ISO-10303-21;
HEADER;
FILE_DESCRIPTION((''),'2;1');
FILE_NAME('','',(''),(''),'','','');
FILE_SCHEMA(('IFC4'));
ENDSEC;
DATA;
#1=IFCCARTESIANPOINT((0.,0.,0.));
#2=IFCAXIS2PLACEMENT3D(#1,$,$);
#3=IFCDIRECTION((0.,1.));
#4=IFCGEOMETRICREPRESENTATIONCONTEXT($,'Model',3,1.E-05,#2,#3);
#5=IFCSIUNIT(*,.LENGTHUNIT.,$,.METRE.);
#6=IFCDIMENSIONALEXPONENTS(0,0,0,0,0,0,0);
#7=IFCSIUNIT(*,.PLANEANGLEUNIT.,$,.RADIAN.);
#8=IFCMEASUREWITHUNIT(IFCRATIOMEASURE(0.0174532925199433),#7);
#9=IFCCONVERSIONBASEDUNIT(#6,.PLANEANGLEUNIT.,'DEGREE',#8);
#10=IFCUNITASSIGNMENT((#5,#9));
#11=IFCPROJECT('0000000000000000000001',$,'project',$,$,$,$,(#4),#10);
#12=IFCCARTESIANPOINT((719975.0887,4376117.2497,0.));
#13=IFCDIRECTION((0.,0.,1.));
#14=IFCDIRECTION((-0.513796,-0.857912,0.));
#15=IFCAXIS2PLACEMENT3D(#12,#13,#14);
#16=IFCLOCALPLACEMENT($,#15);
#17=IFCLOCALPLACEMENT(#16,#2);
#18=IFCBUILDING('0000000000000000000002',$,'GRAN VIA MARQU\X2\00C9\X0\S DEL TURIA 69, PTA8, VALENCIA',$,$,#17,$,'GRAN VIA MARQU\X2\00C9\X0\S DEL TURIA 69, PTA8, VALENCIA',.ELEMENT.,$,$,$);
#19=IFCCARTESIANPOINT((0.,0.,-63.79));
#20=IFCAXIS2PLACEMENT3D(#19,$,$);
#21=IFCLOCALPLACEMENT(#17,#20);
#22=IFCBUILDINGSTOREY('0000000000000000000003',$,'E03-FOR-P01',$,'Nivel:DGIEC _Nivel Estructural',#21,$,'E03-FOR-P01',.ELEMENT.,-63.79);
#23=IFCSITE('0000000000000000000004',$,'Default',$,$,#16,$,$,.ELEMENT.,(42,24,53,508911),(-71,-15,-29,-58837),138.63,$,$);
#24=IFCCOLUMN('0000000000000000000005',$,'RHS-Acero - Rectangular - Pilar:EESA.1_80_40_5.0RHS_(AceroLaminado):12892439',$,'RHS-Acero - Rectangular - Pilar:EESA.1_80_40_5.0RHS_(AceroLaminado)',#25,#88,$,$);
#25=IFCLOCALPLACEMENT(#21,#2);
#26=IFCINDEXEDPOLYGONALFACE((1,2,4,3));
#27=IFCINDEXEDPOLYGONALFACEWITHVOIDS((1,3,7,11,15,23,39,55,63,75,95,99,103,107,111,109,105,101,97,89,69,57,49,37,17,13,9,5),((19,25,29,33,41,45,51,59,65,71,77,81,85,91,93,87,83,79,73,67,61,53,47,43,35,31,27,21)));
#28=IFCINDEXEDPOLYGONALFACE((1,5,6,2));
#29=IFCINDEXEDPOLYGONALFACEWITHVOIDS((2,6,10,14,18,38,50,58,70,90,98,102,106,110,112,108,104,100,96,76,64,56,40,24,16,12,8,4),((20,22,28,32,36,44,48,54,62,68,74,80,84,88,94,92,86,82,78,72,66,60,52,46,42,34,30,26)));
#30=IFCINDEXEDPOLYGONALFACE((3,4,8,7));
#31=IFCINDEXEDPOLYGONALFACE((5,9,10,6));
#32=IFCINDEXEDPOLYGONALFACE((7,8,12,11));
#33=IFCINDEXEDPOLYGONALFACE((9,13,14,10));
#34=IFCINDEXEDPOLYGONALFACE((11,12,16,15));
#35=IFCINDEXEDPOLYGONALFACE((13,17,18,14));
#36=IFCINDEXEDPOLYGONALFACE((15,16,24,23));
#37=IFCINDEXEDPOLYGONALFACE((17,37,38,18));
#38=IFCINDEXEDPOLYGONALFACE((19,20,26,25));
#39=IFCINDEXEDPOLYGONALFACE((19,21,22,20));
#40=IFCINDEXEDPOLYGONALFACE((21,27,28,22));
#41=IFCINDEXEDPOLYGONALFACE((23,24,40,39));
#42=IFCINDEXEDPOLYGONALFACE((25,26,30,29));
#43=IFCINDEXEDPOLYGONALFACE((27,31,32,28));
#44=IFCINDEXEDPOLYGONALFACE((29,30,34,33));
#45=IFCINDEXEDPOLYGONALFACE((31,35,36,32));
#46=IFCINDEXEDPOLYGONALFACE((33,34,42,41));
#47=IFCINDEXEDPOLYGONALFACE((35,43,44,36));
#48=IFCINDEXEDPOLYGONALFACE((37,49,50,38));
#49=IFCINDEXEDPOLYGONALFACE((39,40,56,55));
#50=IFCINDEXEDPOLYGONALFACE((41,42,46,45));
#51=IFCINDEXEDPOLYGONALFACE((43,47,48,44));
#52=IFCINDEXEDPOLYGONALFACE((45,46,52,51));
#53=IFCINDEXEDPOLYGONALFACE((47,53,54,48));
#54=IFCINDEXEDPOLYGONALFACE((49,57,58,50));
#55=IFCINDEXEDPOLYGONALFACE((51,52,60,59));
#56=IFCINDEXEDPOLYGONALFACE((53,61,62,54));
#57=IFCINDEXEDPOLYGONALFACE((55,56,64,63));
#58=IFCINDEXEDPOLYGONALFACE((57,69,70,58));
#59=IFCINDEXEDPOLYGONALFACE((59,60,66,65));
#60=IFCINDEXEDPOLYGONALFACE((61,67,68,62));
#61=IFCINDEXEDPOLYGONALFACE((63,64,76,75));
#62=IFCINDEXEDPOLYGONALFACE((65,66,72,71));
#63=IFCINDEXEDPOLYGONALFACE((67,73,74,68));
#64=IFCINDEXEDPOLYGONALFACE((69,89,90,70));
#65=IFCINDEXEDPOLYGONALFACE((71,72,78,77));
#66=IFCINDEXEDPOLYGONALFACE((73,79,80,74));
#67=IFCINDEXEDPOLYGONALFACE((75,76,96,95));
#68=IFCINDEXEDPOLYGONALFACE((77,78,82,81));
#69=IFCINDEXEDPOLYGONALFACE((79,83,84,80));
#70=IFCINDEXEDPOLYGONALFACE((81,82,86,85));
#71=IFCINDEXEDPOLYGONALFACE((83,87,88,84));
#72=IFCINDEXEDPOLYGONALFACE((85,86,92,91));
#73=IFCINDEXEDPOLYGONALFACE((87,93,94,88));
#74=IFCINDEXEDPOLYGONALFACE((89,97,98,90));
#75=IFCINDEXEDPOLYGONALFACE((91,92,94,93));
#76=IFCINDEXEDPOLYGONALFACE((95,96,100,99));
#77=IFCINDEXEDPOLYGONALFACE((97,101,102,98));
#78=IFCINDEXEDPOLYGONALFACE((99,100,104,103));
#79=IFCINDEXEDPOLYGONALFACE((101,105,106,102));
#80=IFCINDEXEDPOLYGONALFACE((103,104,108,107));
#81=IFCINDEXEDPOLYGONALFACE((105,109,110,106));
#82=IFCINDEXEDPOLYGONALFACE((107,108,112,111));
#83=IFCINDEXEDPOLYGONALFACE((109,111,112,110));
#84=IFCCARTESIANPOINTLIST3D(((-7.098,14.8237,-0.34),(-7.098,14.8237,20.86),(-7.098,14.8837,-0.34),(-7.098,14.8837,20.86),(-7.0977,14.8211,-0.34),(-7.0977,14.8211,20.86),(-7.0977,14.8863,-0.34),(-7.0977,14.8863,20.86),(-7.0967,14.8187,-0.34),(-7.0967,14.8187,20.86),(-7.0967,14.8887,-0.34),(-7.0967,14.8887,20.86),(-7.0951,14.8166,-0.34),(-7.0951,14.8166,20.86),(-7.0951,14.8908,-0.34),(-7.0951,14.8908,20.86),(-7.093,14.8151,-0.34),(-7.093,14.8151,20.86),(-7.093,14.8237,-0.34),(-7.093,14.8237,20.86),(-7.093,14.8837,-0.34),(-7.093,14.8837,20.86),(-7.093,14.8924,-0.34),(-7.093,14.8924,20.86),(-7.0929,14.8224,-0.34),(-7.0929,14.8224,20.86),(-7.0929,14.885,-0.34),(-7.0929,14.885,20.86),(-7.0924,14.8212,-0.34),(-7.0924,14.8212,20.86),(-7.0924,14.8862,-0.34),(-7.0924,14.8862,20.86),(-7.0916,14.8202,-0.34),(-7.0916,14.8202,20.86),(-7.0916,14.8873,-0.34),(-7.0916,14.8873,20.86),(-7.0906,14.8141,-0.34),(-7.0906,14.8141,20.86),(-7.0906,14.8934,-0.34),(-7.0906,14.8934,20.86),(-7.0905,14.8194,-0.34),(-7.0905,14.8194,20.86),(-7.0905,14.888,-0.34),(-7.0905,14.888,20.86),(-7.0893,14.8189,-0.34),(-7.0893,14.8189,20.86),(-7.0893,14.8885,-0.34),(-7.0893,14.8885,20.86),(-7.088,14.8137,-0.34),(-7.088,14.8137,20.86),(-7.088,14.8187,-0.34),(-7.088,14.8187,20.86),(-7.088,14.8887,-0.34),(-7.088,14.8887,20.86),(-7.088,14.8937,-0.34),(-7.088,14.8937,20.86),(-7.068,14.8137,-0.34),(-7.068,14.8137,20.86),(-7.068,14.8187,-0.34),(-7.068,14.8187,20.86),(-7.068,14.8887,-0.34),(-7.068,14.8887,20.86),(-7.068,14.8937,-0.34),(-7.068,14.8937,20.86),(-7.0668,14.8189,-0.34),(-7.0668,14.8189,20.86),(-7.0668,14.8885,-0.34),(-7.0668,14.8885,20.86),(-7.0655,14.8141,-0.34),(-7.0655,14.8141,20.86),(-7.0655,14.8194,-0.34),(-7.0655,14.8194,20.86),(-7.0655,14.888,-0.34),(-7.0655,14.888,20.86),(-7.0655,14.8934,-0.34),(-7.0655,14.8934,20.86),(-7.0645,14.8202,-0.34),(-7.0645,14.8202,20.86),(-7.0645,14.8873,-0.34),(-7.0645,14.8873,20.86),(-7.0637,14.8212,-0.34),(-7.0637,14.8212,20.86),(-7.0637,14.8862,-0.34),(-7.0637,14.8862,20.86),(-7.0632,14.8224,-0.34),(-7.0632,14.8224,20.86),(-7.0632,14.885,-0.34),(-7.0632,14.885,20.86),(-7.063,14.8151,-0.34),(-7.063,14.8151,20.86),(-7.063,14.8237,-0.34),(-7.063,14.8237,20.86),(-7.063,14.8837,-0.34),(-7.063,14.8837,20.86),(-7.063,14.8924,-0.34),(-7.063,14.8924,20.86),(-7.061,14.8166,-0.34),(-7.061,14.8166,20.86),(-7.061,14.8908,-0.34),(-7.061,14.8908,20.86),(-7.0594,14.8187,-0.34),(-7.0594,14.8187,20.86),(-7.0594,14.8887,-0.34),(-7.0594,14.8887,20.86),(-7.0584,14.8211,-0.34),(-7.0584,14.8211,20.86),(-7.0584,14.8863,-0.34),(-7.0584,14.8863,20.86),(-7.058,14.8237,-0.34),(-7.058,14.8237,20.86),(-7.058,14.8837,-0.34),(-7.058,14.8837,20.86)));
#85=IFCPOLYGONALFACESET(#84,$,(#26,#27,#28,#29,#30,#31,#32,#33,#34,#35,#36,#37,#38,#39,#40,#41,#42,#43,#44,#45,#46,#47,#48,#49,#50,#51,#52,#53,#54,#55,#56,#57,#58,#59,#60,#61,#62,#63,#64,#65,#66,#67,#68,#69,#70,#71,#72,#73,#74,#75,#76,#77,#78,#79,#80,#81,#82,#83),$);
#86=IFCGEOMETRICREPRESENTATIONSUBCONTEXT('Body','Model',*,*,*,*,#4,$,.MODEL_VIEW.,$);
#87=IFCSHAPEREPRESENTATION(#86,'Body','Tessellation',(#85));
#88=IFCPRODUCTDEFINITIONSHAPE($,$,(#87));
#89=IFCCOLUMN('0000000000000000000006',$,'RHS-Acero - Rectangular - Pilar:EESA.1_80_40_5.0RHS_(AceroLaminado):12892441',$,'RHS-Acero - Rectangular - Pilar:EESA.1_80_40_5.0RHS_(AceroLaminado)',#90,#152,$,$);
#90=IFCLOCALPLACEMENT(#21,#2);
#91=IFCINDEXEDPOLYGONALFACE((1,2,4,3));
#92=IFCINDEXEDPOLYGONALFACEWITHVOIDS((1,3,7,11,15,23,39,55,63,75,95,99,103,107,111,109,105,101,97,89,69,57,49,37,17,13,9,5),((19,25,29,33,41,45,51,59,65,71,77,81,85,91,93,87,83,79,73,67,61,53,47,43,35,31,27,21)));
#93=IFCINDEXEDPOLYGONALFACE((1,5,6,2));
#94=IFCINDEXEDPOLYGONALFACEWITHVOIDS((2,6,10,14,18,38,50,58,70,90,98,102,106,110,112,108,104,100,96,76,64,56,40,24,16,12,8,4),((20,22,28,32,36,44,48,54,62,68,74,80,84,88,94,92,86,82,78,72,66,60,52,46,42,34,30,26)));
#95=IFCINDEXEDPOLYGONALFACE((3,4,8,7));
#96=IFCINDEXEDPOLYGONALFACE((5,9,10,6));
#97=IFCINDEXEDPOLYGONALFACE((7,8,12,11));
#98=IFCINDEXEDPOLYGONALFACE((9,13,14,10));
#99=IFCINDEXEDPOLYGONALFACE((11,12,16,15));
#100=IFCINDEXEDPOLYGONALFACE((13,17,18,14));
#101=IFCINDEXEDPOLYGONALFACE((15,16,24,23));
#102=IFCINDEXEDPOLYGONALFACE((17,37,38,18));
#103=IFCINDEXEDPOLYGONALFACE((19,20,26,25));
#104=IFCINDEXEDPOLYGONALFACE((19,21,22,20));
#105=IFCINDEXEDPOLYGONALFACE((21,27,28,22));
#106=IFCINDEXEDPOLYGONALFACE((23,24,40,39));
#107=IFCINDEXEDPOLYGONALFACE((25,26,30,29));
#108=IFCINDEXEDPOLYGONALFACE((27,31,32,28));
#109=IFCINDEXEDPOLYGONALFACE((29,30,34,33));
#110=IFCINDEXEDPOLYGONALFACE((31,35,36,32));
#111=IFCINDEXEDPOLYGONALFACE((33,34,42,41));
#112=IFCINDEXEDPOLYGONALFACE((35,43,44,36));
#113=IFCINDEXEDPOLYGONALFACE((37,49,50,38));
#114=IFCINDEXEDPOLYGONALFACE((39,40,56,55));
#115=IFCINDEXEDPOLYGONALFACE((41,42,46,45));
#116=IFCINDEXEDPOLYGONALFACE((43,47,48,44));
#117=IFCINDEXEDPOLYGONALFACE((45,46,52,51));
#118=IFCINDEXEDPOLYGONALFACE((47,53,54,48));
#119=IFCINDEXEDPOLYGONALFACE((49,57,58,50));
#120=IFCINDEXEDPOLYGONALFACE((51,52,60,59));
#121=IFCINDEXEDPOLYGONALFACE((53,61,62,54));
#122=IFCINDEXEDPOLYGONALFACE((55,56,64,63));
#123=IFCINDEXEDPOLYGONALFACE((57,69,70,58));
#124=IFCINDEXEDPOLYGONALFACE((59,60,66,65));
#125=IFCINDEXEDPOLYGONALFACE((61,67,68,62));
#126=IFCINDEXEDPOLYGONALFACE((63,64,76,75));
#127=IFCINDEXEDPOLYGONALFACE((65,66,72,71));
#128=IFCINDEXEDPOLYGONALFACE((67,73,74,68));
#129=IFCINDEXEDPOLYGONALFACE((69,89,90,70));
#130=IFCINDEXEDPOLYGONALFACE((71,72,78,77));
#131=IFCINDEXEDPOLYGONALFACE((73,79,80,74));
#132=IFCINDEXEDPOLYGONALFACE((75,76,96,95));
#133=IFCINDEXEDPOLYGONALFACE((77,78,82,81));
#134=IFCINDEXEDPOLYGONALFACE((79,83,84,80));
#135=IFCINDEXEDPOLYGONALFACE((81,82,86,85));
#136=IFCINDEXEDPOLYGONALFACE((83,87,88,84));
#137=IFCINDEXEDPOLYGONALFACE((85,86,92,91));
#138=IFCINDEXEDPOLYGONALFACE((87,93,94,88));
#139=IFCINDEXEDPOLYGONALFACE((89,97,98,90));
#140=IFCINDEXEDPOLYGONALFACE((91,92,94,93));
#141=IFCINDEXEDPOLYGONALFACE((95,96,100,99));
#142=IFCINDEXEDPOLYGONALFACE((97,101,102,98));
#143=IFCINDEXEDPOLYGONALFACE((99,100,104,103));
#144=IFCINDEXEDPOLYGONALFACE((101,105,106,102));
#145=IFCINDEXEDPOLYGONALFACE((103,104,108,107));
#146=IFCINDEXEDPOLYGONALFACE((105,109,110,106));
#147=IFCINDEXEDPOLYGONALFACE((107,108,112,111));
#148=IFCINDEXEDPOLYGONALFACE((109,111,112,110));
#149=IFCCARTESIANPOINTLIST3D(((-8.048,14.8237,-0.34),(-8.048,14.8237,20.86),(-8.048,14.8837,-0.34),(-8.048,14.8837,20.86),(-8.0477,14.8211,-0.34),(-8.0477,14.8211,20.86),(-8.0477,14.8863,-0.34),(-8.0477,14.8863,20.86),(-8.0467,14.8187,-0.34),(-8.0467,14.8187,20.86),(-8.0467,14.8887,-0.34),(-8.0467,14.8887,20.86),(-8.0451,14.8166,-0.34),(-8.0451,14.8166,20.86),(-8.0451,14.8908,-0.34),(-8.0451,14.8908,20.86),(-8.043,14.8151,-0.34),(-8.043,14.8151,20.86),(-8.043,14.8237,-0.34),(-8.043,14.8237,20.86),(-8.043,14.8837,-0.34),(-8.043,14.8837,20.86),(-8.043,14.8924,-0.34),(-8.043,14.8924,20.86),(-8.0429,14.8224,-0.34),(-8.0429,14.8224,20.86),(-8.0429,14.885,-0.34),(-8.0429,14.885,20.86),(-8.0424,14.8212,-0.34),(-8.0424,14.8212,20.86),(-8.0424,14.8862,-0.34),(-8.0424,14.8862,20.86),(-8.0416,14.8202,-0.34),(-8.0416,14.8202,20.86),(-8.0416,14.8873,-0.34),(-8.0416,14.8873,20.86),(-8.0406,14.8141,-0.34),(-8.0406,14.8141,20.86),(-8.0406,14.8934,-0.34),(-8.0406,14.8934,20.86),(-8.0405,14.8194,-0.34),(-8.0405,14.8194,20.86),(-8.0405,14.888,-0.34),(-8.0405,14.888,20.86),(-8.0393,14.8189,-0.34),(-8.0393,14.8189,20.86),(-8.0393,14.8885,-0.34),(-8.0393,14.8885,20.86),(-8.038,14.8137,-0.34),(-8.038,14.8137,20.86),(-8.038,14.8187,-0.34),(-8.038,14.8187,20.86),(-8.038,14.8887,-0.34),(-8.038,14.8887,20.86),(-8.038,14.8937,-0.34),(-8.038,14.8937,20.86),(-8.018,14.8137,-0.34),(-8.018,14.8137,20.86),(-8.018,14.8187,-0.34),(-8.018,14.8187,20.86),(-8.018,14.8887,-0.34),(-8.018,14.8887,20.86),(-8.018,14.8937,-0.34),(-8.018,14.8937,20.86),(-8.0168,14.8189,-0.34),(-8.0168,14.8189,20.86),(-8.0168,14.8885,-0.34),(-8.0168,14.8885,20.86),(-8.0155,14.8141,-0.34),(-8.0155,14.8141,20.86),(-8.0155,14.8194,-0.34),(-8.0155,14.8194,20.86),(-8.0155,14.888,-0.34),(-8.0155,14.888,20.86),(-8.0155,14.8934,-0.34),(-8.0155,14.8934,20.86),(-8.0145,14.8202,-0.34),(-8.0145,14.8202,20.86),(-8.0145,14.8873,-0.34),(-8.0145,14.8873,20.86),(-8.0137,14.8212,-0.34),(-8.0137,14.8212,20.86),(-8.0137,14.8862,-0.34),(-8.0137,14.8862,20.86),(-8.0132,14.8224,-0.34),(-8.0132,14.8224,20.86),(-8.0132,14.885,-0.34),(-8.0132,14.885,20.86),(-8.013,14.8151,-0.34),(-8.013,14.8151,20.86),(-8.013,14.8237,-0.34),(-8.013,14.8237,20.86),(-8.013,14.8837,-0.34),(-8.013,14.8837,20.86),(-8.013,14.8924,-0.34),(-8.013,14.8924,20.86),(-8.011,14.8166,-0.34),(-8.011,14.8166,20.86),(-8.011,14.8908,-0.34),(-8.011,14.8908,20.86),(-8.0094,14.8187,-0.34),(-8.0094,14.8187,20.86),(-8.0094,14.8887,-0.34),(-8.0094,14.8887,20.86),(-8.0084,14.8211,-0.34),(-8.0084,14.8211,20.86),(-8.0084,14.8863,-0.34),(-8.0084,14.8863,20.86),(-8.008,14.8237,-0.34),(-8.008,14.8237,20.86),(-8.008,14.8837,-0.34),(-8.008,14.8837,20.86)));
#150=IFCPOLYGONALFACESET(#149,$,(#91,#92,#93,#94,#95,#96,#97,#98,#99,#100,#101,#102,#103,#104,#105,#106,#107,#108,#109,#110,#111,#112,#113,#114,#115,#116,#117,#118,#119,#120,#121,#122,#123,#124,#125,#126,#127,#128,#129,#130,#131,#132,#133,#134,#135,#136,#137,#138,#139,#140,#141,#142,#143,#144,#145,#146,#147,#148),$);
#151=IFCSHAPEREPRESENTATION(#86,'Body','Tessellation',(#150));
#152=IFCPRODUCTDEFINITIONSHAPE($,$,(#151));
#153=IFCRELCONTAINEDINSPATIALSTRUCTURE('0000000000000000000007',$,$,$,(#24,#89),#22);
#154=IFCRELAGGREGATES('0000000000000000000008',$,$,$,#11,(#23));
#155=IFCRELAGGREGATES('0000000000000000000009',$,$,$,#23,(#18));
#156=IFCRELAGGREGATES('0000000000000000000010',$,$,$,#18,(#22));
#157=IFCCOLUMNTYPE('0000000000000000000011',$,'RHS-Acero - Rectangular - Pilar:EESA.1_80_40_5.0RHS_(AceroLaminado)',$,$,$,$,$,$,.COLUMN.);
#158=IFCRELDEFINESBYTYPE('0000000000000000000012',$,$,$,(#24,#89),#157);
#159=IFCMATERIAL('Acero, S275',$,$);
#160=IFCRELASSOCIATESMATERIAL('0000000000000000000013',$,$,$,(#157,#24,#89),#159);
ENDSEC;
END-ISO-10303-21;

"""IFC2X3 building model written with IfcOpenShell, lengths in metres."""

from ifc_helpers import new_model, entity, si_unit, converted_unit, direction, frame, frame_2d, origin, place, context, subcontext, project, spatial, polyline, circle_curve, parameter, trimmed, segment, composite_curve, outline, extrude, source, transform, mapped, material, type_object, type_shapes, element, save


model = new_model("IFC2X3")

# Units and contexts
model_context = context("Model", 3, precision=1e-05, world=origin(), true_north=direction((0.0, 1.0)))
body_context = subcontext(model_context, "Body", "Model", "MODEL_VIEW")
ifc_project = project(units=[si_unit("LENGTHUNIT", "METRE"), converted_unit("PLANEANGLEUNIT", "DEGREE", entity("IfcRatioMeasure", 0.0174532925199433), si_unit("PLANEANGLEUNIT", "RADIAN"), dimensions=[0, 0, 0, 0, 0, 0, 0])], contexts=[model_context])

# Site, building, storey
site_placement = place(None, frame((719975.0887, 4376117.2497, 0.0), z_axis=(0.0, 0.0, 1.0), x_axis=(-0.513796, -0.857912, 0.0)))
site = spatial("IfcSite", under=ifc_project, at=site_placement, Name="Default", CompositionType="ELEMENT", RefLatitude=(42, 24, 53, 508911), RefLongitude=(-71, -15, -29, -58837), RefElevation=138.63)
building_placement = place(site_placement, origin())
building = spatial("IfcBuilding", under=site, at=building_placement, Name="GRAN VIA MARQUÉS DEL TURIA 69, PTA8, VALENCIA", LongName="GRAN VIA MARQUÉS DEL TURIA 69, PTA8, VALENCIA", CompositionType="ELEMENT")
storey_placement = place(building_placement, frame((0.0, 0.0, -63.79)))
storey = spatial("IfcBuildingStorey", under=building, at=storey_placement, Name="E03-FOR-P01", ObjectType="Nivel:DGIEC _Nivel Estructural", LongName="E03-FOR-P01", CompositionType="ELEMENT", Elevation=-63.79)

# Columns
ifc_material_1 = material(Name="Acero, S275")
column_type_1 = type_object("IfcColumnType", Name="RHS-Acero - Rectangular - Pilar:EESA.1_80_40_5.0RHS_(AceroLaminado)", PredefinedType="COLUMN", material=ifc_material_1)
shared_shape_1 = source(origin(), body_context, "Body", "SweptSolid", [
    extrude(outline(composite_curve([segment(polyline([(-0.01, -0.04), (0.01, -0.04)]), True, "CONTINUOUS"), segment(trimmed(circle_curve(frame_2d((0.01, -0.03), x_axis=(-1.0, 0.0)), 0.01), [parameter(90.0)], [parameter(180.0)], True, "PARAMETER"), True, "CONTINUOUS"), segment(polyline([(0.02, -0.03), (0.02, 0.03)]), True, "CONTINUOUS"), segment(trimmed(circle_curve(frame_2d((0.01, 0.03), x_axis=(-1.0, 0.0)), 0.01), [parameter(180.0)], [parameter(270.0)], True, "PARAMETER"), True, "CONTINUOUS"), segment(polyline([(0.01, 0.04), (-0.01, 0.04)]), True, "CONTINUOUS"), segment(trimmed(circle_curve(frame_2d((-0.01, 0.03), x_axis=(-1.0, 0.0)), 0.01), [parameter(270.0)], [parameter(360.0)], True, "PARAMETER"), True, "CONTINUOUS"), segment(polyline([(-0.02, 0.03), (-0.02, -0.03)]), True, "CONTINUOUS"), segment(trimmed(circle_curve(frame_2d((-0.01, -0.03), x_axis=(-1.0, 0.0)), 0.01), [parameter(360.0)], [parameter(90.0)], True, "PARAMETER"), True, "CONTINUOUS")], self_intersect=False), holes=[composite_curve([segment(trimmed(circle_curve(frame_2d((-0.01, -0.03), x_axis=(-1.0, 0.0)), 0.005), [parameter(0.0)], [parameter(90.0)], True, "PARAMETER"), False, "CONTINUOUS"), segment(polyline([(-0.015, -0.03), (-0.015, 0.03)]), True, "CONTINUOUS"), segment(trimmed(circle_curve(frame_2d((-0.01, 0.03), x_axis=(-1.0, 0.0)), 0.005), [parameter(270.0)], [parameter(0.0)], True, "PARAMETER"), False, "CONTINUOUS"), segment(polyline([(-0.01, 0.035), (0.01, 0.035)]), True, "CONTINUOUS"), segment(trimmed(circle_curve(frame_2d((0.01, 0.03), x_axis=(-1.0, 0.0)), 0.005), [parameter(180.0)], [parameter(270.0)], True, "PARAMETER"), False, "CONTINUOUS"), segment(polyline([(0.015, 0.03), (0.015, -0.03)]), True, "CONTINUOUS"), segment(trimmed(circle_curve(frame_2d((0.01, -0.03), x_axis=(-1.0, 0.0)), 0.005), [parameter(90.0)], [parameter(180.0)], True, "PARAMETER"), False, "CONTINUOUS"), segment(polyline([(0.01, -0.035), (-0.01, -0.035)]), True, "CONTINUOUS")], self_intersect=False)]), frame((0.0, 0.0, -64.13), z_axis=(0.0, 0.0, 1.0), x_axis=(-1.0, 0.0, 0.0)), (0.0, 0.0, 1.0), 21.2),
])
type_shapes(column_type_1, [shared_shape_1])
for number, where, z_axis, x_axis, name in (
    (1, (-7.078, 14.8537, 63.79), (0.0, 0.0, 1.0), (-1.0, 0.0, 0.0), "RHS-Acero - Rectangular - Pilar:EESA.1_80_40_5.0RHS_(AceroLaminado):12892439"),
    (2, (-8.028, 14.8537, 63.79), (0.0, 0.0, 1.0), (-1.0, 0.0, 0.0), "RHS-Acero - Rectangular - Pilar:EESA.1_80_40_5.0RHS_(AceroLaminado):12892441"),
):
    element("IfcColumn", number, at=place(storey_placement, frame(where, z_axis=z_axis, x_axis=x_axis)), inside=storey, type_object=column_type_1, material=ifc_material_1, Name=name, ObjectType="RHS-Acero - Rectangular - Pilar:EESA.1_80_40_5.0RHS_(AceroLaminado)", context=body_context, shape_type="MappedRepresentation", body=[
        mapped(shared_shape_1, transform((0.0, 0.0, 0.0), scale=1.0)),
    ])

save(model, "model.ifc")
